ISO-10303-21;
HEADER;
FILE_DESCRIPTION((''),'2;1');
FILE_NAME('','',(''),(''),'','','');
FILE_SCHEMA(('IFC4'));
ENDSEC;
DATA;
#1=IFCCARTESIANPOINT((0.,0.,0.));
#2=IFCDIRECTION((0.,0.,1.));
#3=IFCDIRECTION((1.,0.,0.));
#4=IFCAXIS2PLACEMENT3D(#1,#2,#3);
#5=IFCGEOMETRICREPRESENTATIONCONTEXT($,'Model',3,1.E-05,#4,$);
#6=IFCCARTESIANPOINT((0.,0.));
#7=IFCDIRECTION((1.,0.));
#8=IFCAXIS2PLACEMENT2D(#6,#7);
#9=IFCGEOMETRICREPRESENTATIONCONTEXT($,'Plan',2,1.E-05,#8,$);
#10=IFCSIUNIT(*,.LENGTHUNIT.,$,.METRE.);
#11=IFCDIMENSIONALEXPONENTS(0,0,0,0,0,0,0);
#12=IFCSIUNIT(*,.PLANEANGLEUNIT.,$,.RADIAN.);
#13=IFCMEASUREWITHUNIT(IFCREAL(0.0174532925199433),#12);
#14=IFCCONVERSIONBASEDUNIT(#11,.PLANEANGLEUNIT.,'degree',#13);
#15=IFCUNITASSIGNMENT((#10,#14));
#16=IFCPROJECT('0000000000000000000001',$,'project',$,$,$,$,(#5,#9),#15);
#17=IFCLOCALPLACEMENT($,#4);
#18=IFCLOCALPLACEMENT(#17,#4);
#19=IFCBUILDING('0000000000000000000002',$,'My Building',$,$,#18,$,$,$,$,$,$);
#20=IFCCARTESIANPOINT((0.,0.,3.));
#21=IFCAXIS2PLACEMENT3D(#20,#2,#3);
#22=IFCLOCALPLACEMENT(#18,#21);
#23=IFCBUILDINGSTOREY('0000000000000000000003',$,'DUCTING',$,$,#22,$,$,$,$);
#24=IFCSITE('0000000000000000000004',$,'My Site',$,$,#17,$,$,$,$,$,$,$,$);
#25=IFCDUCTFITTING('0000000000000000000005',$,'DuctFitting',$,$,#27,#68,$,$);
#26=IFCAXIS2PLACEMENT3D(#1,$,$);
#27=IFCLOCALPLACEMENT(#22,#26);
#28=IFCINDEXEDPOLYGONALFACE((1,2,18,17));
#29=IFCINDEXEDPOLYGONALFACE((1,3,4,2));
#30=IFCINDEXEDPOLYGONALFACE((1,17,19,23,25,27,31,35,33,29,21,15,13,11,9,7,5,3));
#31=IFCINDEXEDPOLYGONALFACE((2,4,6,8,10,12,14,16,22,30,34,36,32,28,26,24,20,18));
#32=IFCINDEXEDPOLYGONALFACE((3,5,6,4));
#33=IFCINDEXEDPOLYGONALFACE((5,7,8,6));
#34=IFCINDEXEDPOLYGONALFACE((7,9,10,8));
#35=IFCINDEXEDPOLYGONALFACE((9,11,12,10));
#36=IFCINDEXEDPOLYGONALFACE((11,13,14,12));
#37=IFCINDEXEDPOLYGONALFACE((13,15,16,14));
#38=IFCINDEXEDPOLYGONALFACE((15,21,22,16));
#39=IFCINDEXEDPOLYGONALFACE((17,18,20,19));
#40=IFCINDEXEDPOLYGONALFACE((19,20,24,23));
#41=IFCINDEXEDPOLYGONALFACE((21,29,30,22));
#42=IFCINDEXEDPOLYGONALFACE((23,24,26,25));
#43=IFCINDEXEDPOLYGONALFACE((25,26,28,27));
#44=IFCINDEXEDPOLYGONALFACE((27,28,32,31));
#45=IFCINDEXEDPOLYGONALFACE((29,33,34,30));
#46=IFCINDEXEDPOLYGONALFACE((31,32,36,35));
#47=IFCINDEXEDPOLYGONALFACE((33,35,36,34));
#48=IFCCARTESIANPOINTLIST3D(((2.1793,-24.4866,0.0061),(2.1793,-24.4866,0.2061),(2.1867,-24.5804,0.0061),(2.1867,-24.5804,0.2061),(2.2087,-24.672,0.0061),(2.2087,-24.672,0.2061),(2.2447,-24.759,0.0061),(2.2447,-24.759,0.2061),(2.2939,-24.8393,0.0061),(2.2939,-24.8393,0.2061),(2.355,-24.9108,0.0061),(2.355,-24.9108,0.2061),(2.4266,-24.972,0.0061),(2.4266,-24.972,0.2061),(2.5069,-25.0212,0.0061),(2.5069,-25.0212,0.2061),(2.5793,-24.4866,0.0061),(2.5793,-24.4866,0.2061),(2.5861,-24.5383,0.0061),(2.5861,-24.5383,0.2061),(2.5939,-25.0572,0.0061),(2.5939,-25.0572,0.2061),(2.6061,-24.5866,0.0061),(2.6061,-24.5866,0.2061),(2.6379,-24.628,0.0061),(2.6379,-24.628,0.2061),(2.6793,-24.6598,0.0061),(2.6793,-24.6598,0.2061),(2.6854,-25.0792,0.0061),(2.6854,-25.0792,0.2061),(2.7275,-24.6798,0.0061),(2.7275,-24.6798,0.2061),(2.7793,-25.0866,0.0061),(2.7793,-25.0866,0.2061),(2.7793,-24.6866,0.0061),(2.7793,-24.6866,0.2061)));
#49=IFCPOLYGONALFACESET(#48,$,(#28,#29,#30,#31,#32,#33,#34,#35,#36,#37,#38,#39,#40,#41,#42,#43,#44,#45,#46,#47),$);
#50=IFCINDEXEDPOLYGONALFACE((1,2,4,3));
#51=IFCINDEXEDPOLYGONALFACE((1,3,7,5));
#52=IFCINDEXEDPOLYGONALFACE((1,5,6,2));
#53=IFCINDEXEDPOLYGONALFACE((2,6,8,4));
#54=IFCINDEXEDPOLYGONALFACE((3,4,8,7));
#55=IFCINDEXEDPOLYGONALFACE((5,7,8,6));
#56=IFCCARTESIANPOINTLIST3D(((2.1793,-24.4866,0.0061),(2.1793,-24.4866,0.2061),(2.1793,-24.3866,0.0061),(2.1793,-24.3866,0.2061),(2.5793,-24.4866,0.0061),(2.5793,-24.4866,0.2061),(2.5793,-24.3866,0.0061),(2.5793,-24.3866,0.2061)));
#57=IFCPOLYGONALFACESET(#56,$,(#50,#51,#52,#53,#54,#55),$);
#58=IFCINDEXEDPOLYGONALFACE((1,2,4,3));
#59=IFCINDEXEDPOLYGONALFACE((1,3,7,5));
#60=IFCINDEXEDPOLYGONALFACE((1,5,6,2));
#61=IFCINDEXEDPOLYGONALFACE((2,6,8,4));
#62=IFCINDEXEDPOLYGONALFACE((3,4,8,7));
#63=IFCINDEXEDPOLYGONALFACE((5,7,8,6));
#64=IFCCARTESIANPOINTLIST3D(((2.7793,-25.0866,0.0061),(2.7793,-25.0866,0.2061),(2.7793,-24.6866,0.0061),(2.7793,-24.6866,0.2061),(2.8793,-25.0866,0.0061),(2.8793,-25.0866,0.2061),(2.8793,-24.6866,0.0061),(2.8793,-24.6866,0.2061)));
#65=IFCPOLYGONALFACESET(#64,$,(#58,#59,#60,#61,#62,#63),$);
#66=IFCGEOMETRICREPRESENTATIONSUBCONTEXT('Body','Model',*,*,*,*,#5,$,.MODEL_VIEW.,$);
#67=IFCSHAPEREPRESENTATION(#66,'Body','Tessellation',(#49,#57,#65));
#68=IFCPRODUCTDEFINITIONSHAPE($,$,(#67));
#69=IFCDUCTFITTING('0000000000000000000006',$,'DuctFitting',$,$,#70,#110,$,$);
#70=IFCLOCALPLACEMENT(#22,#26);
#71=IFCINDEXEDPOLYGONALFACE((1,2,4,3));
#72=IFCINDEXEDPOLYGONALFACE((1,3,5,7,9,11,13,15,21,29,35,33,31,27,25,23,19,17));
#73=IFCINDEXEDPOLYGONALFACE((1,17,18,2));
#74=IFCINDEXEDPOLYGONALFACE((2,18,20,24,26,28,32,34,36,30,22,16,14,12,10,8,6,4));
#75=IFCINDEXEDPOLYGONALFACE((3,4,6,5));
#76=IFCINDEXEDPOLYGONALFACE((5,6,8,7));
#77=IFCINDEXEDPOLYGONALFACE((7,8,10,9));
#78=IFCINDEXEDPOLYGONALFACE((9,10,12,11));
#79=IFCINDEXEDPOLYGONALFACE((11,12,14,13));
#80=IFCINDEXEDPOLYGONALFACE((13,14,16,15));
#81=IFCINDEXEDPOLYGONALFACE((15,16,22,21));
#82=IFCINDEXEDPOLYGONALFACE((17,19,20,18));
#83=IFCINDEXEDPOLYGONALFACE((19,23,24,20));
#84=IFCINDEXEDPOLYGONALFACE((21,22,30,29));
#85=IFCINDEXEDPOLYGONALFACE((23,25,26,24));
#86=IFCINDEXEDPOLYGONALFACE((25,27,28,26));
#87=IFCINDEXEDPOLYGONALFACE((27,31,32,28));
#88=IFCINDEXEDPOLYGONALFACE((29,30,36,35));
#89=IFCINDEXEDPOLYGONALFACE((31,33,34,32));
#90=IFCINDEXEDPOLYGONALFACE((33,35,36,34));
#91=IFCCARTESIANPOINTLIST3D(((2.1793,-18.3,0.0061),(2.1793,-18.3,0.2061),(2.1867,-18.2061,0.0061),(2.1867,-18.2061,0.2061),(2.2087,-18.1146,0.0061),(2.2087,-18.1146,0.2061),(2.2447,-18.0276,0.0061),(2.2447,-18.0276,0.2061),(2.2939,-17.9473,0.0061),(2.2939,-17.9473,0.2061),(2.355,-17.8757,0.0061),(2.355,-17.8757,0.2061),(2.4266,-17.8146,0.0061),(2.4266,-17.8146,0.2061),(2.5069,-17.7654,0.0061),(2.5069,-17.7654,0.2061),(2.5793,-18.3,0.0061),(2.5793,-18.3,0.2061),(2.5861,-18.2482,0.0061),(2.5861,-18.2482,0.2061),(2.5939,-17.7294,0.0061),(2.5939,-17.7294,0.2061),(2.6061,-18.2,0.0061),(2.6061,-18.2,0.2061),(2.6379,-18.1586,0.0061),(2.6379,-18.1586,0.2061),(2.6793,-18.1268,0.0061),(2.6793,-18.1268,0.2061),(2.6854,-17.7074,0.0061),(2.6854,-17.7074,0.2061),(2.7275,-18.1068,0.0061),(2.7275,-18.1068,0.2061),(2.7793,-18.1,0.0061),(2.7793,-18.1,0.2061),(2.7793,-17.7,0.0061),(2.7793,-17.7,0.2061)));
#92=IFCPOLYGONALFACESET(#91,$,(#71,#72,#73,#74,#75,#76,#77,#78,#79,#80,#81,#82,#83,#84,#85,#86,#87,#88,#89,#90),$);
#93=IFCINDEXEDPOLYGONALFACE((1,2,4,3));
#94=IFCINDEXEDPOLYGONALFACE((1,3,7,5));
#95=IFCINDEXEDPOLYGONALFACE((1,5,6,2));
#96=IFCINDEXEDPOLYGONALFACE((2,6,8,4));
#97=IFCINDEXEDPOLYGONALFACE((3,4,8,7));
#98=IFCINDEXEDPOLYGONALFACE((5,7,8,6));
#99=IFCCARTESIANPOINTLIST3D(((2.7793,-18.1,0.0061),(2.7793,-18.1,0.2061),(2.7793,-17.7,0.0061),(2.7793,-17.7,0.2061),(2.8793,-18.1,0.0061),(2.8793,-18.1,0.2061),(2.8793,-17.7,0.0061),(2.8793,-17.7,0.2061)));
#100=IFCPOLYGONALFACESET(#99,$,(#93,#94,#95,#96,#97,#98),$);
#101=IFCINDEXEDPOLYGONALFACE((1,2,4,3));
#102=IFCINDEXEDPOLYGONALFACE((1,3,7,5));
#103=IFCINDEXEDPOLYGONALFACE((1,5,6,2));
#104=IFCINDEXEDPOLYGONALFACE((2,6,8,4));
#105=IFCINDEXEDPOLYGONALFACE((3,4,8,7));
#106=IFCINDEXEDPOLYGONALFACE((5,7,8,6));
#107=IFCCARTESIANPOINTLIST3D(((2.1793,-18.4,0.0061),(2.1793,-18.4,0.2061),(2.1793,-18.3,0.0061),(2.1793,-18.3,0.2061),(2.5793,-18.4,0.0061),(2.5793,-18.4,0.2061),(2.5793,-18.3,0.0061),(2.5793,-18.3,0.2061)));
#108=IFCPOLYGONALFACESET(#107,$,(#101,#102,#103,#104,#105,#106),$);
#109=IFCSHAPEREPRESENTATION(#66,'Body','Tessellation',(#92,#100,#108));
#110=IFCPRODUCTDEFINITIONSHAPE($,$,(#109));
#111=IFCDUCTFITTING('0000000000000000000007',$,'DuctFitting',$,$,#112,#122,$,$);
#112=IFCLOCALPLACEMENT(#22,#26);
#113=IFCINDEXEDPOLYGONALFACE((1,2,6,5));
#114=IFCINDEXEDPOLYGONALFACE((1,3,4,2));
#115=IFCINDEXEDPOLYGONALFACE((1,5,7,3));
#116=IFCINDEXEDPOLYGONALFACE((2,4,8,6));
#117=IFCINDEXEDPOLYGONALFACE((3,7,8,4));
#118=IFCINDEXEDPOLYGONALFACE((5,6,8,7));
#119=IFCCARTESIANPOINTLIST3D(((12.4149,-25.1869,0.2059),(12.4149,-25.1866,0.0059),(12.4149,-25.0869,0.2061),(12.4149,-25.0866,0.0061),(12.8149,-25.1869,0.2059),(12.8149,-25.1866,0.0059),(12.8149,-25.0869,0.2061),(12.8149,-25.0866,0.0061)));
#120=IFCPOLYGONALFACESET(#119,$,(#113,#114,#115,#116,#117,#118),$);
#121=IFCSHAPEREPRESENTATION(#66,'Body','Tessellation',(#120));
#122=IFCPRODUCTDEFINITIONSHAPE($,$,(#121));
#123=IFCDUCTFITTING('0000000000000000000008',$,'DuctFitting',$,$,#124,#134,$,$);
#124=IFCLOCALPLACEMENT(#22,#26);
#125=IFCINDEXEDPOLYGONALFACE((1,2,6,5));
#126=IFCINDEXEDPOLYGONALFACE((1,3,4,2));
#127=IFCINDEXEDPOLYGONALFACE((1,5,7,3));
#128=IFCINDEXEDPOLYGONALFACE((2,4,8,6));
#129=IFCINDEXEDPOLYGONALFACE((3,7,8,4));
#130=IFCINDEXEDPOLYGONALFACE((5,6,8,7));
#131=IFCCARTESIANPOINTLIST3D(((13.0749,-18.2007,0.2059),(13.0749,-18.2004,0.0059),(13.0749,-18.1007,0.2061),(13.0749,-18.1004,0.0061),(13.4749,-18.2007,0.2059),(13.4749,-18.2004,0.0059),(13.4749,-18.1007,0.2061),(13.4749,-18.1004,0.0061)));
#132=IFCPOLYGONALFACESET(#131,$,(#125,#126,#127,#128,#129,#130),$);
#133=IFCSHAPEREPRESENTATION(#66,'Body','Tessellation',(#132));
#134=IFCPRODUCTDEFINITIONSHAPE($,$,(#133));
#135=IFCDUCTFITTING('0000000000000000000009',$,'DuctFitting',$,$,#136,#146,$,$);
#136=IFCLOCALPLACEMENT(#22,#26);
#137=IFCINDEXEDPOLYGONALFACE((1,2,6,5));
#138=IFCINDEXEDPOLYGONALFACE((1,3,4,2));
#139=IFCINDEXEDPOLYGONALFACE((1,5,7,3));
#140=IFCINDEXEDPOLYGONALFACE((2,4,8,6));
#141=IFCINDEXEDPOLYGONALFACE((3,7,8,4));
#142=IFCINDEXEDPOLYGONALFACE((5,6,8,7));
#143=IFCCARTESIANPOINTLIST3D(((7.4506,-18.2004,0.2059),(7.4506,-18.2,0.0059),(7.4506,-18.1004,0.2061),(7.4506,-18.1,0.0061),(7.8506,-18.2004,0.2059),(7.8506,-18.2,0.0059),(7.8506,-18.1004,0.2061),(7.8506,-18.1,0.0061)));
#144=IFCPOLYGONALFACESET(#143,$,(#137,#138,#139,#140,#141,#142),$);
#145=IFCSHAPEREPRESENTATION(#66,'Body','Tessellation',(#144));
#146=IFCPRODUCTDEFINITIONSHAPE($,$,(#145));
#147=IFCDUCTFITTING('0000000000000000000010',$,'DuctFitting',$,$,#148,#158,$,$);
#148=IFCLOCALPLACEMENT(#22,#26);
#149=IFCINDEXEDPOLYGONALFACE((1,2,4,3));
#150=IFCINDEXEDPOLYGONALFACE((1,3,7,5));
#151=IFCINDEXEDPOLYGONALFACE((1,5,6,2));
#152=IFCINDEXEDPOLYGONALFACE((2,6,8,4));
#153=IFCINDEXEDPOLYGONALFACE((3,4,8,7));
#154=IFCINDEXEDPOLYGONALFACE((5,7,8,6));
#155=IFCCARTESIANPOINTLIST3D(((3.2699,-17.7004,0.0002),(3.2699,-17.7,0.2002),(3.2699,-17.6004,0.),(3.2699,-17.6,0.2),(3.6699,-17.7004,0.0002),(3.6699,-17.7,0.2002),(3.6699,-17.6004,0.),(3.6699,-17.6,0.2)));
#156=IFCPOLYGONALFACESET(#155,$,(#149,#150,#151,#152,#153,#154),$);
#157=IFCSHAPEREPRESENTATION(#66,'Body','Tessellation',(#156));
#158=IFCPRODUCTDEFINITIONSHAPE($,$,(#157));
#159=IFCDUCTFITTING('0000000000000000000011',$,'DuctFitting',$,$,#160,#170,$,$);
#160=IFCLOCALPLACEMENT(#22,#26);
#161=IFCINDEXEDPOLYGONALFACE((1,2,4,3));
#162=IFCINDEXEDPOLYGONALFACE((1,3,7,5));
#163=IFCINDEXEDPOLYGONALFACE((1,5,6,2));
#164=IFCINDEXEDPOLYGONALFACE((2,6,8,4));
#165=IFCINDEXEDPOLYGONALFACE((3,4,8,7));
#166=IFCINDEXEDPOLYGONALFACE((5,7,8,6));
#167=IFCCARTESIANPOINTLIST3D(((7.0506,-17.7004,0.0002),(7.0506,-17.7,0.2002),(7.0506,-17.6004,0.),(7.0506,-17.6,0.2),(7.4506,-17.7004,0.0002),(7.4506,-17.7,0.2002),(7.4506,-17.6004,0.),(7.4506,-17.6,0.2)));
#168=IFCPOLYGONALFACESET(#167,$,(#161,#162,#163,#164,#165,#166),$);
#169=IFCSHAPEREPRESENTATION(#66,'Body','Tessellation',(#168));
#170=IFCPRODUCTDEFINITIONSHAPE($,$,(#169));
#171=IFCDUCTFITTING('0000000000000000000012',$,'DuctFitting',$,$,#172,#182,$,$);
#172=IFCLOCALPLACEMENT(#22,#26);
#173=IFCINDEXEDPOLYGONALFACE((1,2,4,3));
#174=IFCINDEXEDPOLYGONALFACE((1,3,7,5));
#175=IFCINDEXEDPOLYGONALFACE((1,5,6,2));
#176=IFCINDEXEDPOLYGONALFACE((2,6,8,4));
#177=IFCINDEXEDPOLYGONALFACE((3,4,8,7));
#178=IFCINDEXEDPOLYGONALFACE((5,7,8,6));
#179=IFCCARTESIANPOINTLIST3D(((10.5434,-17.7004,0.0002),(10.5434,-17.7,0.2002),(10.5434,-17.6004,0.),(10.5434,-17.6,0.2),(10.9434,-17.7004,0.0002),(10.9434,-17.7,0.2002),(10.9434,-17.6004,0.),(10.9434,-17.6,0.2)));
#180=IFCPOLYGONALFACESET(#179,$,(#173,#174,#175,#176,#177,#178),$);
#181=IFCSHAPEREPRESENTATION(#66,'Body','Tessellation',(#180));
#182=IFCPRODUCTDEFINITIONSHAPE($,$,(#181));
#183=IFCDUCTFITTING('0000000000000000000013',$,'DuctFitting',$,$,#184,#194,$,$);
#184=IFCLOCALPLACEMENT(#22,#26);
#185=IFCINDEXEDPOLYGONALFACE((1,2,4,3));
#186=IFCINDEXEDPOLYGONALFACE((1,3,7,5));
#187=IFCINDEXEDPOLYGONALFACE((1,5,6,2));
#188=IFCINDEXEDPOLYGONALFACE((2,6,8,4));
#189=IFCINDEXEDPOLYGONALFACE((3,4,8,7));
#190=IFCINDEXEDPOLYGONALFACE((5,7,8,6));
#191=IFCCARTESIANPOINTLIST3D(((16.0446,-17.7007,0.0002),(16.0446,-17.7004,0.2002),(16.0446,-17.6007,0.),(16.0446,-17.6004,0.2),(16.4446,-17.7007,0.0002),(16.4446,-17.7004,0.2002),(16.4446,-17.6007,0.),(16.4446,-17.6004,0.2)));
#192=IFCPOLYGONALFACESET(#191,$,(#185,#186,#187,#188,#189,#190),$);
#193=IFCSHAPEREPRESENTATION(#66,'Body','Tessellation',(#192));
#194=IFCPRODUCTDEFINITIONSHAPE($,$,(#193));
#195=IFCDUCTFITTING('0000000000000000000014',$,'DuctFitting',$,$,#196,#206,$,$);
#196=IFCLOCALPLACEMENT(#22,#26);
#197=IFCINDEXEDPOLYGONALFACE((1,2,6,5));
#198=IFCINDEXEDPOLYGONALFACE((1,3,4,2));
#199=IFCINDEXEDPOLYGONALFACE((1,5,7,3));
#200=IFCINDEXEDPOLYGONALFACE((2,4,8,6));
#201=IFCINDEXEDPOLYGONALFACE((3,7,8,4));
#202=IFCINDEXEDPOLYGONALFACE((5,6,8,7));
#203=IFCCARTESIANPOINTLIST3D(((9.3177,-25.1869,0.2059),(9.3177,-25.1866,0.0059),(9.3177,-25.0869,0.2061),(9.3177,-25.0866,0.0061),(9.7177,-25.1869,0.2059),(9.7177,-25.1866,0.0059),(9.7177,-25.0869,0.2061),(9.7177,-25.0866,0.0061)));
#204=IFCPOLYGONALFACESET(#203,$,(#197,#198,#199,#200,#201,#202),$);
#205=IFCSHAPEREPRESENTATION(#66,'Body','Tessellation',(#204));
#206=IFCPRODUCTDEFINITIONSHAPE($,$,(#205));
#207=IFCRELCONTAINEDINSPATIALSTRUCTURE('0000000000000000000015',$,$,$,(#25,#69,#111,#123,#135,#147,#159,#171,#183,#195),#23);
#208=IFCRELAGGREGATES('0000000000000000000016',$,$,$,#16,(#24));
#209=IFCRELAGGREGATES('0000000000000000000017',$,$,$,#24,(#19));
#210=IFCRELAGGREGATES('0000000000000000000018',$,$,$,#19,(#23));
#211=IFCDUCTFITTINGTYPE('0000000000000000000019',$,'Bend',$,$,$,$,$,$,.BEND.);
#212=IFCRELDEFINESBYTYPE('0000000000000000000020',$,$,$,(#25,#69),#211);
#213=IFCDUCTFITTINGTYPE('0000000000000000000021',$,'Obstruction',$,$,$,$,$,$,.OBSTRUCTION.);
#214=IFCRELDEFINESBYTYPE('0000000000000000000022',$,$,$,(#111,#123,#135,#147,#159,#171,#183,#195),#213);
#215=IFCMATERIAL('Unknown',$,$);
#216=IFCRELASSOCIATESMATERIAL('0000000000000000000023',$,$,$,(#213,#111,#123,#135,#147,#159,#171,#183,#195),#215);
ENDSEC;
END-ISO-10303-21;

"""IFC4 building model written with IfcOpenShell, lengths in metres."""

from ifc_helpers import new_model, entity, si_unit, converted_unit, frame, origin_with_axes, origin_2d_with_axis, place, context, subcontext, project, spatial, line, arc, indexed_curve, rectangle, outline, extrude, source, transform, mapped, material, material_profile, profile_set, profile_usage, type_object, type_shapes, element, save


model = new_model("IFC4")

# Units and contexts
model_context = context("Model", 3, precision=1e-05, world=origin_with_axes())
plan_context = context("Plan", 2, precision=1e-05, world=origin_2d_with_axis())
body_context = subcontext(model_context, "Body", "Model", "MODEL_VIEW")
ifc_project = project(units=[si_unit("LENGTHUNIT", "METRE"), converted_unit("PLANEANGLEUNIT", "degree", entity("IfcReal", 0.0174532925199433), si_unit("PLANEANGLEUNIT", "RADIAN"), dimensions=[0, 0, 0, 0, 0, 0, 0])], contexts=[model_context, plan_context])

# Site, building, storey
site_placement = place(None, origin_with_axes())
site = spatial("IfcSite", under=ifc_project, at=site_placement, Name="My Site")
building_placement = place(site_placement, origin_with_axes())
building = spatial("IfcBuilding", under=site, at=building_placement, Name="My Building")
storey_placement = place(building_placement, frame((0.0, 0.0, 3.0), z_axis=(0.0, 0.0, 1.0), x_axis=(1.0, 0.0, 0.0)))
storey = spatial("IfcBuildingStorey", under=building, at=storey_placement, Name="DUCTING")

# Shared definitions
ifc_material = material(Name="Unknown")

# Duct fittings
duct_fitting_type_1 = type_object("IfcDuctFittingType", Name="Bend", PredefinedType="BEND")
shared_shape = source(origin_with_axes(), body_context, "Body", "SweptSolid", [
    extrude(outline(indexed_curve([(-0.2, 0.0), (-0.2586, -0.1414), (-0.4, -0.2), (-0.4, -0.6), (0.0243, -0.4243), (0.2, 0.0)], segments=[arc(1, 2, 3), line(3, 4), arc(4, 5, 6), line(6, 1)])), frame((0.0, -0.1, -0.1), z_axis=(0.0, -1.0, 0.0), x_axis=(1.0, 0.0, 0.0)), (0.0, 0.0, -1.0), 0.2),
    extrude(rectangle(XDim=0.4, YDim=0.2), origin_with_axes(), (0.0, 0.0, -1.0), 0.1),
    extrude(rectangle(XDim=0.4, YDim=0.2), frame((-0.4, 0.0, -0.5), z_axis=(-1.0, 0.0, 0.0), x_axis=(0.0, 0.0, -1.0)), (0.0, 0.0, 1.0), 0.1),
])
type_shapes(duct_fitting_type_1, [shared_shape])
for number, where, z_axis, x_axis, name in (
    (1, (2.3793, -24.3866, 0.1061), (0.0, 1.0, 0.0), (-1.0, 0.0, 0.0), "DuctFitting"),
    (2, (2.8793, -17.9, 0.1061), (1.0, 0.0, 0.0), (0.0, 1.0, 0.0), "DuctFitting"),
):
    element("IfcDuctFitting", number, at=place(storey_placement, frame(where, z_axis=z_axis, x_axis=x_axis)), inside=storey, type_object=duct_fitting_type_1, Name=name, context=body_context, shape_type="MappedRepresentation", body=[
        mapped(shared_shape, transform((0.0, 0.0, 0.0), x_axis=(1.0, 0.0, 0.0), y_axis=(0.0, 1.0, 0.0), z_axis=(0.0, 0.0, 1.0), scale=1.0)),
    ])
ifc_material_profile_1 = material_profile(ifc_material, rectangle(XDim=0.4, YDim=0.2))
ifc_profile_set_1 = profile_set([ifc_material_profile_1])
ifc_profile_usage_1 = profile_usage(ifc_profile_set_1, cardinal=5)
duct_fitting_type_2 = type_object("IfcDuctFittingType", Name="Obstruction", PredefinedType="OBSTRUCTION", material=ifc_profile_set_1)
duct_fitting_1_placement = place(storey_placement, frame((12.6149, -25.0867, 0.1061), z_axis=(0.0, -0.999998, -0.001745), x_axis=(1.0, 0.0, 0.0)))
element("IfcDuctFitting", 3, at=duct_fitting_1_placement, inside=storey, type_object=duct_fitting_type_2, material=ifc_profile_usage_1, Name="DuctFitting", context=body_context, shape_type="SweptSolid", body=[
    extrude(rectangle(XDim=0.4, YDim=0.2), origin_with_axes(), (0.0, 0.0, 1.0), 0.1),
])
ifc_profile_usage_2 = profile_usage(ifc_profile_set_1, cardinal=5)
duct_fitting_2_placement = place(storey_placement, frame((13.2749, -18.1005, 0.1061), z_axis=(0.0, -0.999998, -0.001745), x_axis=(1.0, 0.0, 0.0)))
element("IfcDuctFitting", 4, at=duct_fitting_2_placement, inside=storey, type_object=duct_fitting_type_2, material=ifc_profile_usage_2, Name="DuctFitting", context=body_context, shape_type="SweptSolid", body=[
    extrude(rectangle(XDim=0.4, YDim=0.2), origin_with_axes(), (0.0, 0.0, 1.0), 0.1),
])
ifc_profile_usage_3 = profile_usage(ifc_profile_set_1, cardinal=5)
duct_fitting_3_placement = place(storey_placement, frame((7.6506, -18.1002, 0.1061), z_axis=(0.0, -0.999998, -0.001745), x_axis=(1.0, 0.0, 0.0)))
element("IfcDuctFitting", 5, at=duct_fitting_3_placement, inside=storey, type_object=duct_fitting_type_2, material=ifc_profile_usage_3, Name="DuctFitting", context=body_context, shape_type="SweptSolid", body=[
    extrude(rectangle(XDim=0.4, YDim=0.2), origin_with_axes(), (0.0, 0.0, 1.0), 0.1),
])
ifc_profile_usage_4 = profile_usage(ifc_profile_set_1, cardinal=5)
duct_fitting_4_placement = place(storey_placement, frame((3.4699, -17.7002, 0.1002), z_axis=(0.0, 0.999998, -0.001745), x_axis=(-1.0, 0.0, 0.0)))
element("IfcDuctFitting", 6, at=duct_fitting_4_placement, inside=storey, type_object=duct_fitting_type_2, material=ifc_profile_usage_4, Name="DuctFitting", context=body_context, shape_type="SweptSolid", body=[
    extrude(rectangle(XDim=0.4, YDim=0.2), origin_with_axes(), (0.0, 0.0, 1.0), 0.1),
])
ifc_profile_usage_5 = profile_usage(ifc_profile_set_1, cardinal=5)
duct_fitting_5_placement = place(storey_placement, frame((7.2506, -17.7002, 0.1002), z_axis=(0.0, 0.999998, -0.001745), x_axis=(-1.0, 0.0, 0.0)))
element("IfcDuctFitting", 7, at=duct_fitting_5_placement, inside=storey, type_object=duct_fitting_type_2, material=ifc_profile_usage_5, Name="DuctFitting", context=body_context, shape_type="SweptSolid", body=[
    extrude(rectangle(XDim=0.4, YDim=0.2), origin_with_axes(), (0.0, 0.0, 1.0), 0.1),
])
ifc_profile_usage_6 = profile_usage(ifc_profile_set_1, cardinal=5)
duct_fitting_6_placement = place(storey_placement, frame((10.7434, -17.7002, 0.1002), z_axis=(0.0, 0.999998, -0.001745), x_axis=(-1.0, 0.0, 0.0)))
element("IfcDuctFitting", 8, at=duct_fitting_6_placement, inside=storey, type_object=duct_fitting_type_2, material=ifc_profile_usage_6, Name="DuctFitting", context=body_context, shape_type="SweptSolid", body=[
    extrude(rectangle(XDim=0.4, YDim=0.2), origin_with_axes(), (0.0, 0.0, 1.0), 0.1),
])
ifc_profile_usage_7 = profile_usage(ifc_profile_set_1, cardinal=5)
duct_fitting_7_placement = place(storey_placement, frame((16.2446, -17.7006, 0.1002), z_axis=(0.0, 0.999998, -0.001745), x_axis=(-1.0, 0.0, 0.0)))
element("IfcDuctFitting", 9, at=duct_fitting_7_placement, inside=storey, type_object=duct_fitting_type_2, material=ifc_profile_usage_7, Name="DuctFitting", context=body_context, shape_type="SweptSolid", body=[
    extrude(rectangle(XDim=0.4, YDim=0.2), origin_with_axes(), (0.0, 0.0, 1.0), 0.1),
])
ifc_profile_usage_8 = profile_usage(ifc_profile_set_1, cardinal=5)
duct_fitting_8_placement = place(storey_placement, frame((9.5177, -25.0867, 0.1061), z_axis=(0.0, -0.999998, -0.001745), x_axis=(1.0, 0.0, 0.0)))
element("IfcDuctFitting", 10, at=duct_fitting_8_placement, inside=storey, type_object=duct_fitting_type_2, material=ifc_profile_usage_8, Name="DuctFitting", context=body_context, shape_type="SweptSolid", body=[
    extrude(rectangle(XDim=0.4, YDim=0.2), origin_with_axes(), (0.0, 0.0, 1.0), 0.1),
])

save(model, "model.ifc")
